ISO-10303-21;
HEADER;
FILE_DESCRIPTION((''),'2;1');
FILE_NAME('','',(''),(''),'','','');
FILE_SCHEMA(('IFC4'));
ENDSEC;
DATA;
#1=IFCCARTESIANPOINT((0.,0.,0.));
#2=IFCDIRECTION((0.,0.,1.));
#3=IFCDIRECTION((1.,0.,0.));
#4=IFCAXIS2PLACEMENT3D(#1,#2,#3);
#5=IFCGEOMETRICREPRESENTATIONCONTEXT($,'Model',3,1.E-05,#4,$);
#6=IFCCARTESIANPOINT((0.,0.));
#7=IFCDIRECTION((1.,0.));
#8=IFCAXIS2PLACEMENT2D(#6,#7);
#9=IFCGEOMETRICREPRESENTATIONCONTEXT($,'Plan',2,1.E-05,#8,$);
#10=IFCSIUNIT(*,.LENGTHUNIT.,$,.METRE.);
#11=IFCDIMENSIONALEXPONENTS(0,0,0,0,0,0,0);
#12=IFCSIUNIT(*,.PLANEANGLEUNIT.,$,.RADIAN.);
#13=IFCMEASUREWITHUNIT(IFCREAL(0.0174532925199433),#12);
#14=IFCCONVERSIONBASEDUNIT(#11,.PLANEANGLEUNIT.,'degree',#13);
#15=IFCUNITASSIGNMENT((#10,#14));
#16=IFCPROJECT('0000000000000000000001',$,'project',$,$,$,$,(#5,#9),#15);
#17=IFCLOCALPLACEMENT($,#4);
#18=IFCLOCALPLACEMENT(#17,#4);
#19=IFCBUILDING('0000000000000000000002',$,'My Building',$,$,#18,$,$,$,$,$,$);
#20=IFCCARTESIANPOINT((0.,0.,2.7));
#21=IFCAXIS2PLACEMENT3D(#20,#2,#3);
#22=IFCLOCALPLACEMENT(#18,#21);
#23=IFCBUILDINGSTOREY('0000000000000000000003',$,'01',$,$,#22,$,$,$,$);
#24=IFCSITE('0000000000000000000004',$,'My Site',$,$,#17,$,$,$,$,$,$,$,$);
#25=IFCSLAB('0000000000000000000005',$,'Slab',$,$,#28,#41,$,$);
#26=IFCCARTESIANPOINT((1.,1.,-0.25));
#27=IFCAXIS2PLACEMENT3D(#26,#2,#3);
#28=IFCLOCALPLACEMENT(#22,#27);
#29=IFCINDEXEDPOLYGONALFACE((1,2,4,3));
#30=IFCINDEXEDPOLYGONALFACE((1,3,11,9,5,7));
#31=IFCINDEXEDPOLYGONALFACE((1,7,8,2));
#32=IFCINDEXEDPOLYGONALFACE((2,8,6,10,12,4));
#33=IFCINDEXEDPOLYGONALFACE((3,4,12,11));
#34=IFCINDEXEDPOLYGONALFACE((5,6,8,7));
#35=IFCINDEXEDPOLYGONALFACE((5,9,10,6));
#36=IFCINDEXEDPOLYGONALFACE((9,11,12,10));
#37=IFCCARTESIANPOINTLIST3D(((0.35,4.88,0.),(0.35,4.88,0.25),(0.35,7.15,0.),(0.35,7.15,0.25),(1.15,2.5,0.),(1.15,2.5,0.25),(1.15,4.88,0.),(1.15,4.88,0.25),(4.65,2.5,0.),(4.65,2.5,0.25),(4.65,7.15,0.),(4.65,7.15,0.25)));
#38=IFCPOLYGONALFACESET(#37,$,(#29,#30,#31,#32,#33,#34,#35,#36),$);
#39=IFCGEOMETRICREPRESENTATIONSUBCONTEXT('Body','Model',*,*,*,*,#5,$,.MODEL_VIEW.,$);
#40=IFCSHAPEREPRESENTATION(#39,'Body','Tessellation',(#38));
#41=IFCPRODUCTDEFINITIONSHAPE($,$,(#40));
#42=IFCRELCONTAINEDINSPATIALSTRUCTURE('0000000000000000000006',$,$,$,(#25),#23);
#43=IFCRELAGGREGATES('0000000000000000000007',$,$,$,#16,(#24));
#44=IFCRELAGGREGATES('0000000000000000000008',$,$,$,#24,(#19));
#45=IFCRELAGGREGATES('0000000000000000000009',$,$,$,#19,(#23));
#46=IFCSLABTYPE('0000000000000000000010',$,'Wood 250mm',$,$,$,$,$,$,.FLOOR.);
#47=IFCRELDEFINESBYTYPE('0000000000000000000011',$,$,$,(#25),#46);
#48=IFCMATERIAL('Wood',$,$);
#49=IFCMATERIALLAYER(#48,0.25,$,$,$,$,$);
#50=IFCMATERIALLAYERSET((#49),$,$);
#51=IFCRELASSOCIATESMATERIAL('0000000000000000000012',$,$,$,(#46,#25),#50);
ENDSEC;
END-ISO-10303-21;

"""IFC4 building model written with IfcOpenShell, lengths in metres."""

from ifc_helpers import new_model, entity, si_unit, converted_unit, frame, origin_with_axes, origin_2d_with_axis, place, context, subcontext, project, spatial, line, indexed_curve, outline, extrude, material, layer, layer_set, layer_usage, type_object, element, save


model = new_model("IFC4")

# Units and contexts
model_context = context("Model", 3, precision=1e-05, world=origin_with_axes())
plan_context = context("Plan", 2, precision=1e-05, world=origin_2d_with_axis())
body_context_1 = subcontext(model_context, "Body", "Model", "MODEL_VIEW")
ifc_project = project(units=[si_unit("LENGTHUNIT", "METRE"), converted_unit("PLANEANGLEUNIT", "degree", entity("IfcReal", 0.0174532925199433), si_unit("PLANEANGLEUNIT", "RADIAN"), dimensions=[0, 0, 0, 0, 0, 0, 0])], contexts=[model_context, plan_context])

# Site, building, storey
site_placement = place(None, origin_with_axes())
site = spatial("IfcSite", under=ifc_project, at=site_placement, Name="My Site")
building_placement = place(site_placement, origin_with_axes())
building = spatial("IfcBuilding", under=site, at=building_placement, Name="My Building")
storey_placement = place(building_placement, frame((0.0, 0.0, 2.7), z_axis=(0.0, 0.0, 1.0), x_axis=(1.0, 0.0, 0.0)))
storey = spatial("IfcBuildingStorey", under=building, at=storey_placement, Name="01")

# Slab
ifc_material_1 = material(Name="Wood")
ifc_layer_1 = layer(ifc_material_1, 0.25)
ifc_layer_set_1 = layer_set([ifc_layer_1])
ifc_layer_usage_1 = layer_usage(ifc_layer_set_1, "AXIS3", "POSITIVE", 0.0)
slab_type = type_object("IfcSlabType", Name="Wood 250mm", PredefinedType="FLOOR", material=ifc_layer_set_1)
slab_placement = place(storey_placement, frame((1.0, 1.0, -0.25), z_axis=(0.0, 0.0, 1.0), x_axis=(1.0, 0.0, 0.0)))
element("IfcSlab", 1, at=slab_placement, inside=storey, type_object=slab_type, material=ifc_layer_usage_1, Name="Slab", context=body_context_1, shape_type="SweptSolid", body=[
    extrude(outline(indexed_curve([(4.65, 2.5), (4.65, 7.15), (0.35, 7.15), (0.35, 4.88), (1.15, 4.88), (1.15, 2.5)], segments=[line(3, 2), line(2, 1), line(1, 6), line(6, 5), line(5, 4), line(4, 3)], self_intersect=False)), None, (0.0, 0.0, 1.0), 0.25),
])

save(model, "model.ifc")
